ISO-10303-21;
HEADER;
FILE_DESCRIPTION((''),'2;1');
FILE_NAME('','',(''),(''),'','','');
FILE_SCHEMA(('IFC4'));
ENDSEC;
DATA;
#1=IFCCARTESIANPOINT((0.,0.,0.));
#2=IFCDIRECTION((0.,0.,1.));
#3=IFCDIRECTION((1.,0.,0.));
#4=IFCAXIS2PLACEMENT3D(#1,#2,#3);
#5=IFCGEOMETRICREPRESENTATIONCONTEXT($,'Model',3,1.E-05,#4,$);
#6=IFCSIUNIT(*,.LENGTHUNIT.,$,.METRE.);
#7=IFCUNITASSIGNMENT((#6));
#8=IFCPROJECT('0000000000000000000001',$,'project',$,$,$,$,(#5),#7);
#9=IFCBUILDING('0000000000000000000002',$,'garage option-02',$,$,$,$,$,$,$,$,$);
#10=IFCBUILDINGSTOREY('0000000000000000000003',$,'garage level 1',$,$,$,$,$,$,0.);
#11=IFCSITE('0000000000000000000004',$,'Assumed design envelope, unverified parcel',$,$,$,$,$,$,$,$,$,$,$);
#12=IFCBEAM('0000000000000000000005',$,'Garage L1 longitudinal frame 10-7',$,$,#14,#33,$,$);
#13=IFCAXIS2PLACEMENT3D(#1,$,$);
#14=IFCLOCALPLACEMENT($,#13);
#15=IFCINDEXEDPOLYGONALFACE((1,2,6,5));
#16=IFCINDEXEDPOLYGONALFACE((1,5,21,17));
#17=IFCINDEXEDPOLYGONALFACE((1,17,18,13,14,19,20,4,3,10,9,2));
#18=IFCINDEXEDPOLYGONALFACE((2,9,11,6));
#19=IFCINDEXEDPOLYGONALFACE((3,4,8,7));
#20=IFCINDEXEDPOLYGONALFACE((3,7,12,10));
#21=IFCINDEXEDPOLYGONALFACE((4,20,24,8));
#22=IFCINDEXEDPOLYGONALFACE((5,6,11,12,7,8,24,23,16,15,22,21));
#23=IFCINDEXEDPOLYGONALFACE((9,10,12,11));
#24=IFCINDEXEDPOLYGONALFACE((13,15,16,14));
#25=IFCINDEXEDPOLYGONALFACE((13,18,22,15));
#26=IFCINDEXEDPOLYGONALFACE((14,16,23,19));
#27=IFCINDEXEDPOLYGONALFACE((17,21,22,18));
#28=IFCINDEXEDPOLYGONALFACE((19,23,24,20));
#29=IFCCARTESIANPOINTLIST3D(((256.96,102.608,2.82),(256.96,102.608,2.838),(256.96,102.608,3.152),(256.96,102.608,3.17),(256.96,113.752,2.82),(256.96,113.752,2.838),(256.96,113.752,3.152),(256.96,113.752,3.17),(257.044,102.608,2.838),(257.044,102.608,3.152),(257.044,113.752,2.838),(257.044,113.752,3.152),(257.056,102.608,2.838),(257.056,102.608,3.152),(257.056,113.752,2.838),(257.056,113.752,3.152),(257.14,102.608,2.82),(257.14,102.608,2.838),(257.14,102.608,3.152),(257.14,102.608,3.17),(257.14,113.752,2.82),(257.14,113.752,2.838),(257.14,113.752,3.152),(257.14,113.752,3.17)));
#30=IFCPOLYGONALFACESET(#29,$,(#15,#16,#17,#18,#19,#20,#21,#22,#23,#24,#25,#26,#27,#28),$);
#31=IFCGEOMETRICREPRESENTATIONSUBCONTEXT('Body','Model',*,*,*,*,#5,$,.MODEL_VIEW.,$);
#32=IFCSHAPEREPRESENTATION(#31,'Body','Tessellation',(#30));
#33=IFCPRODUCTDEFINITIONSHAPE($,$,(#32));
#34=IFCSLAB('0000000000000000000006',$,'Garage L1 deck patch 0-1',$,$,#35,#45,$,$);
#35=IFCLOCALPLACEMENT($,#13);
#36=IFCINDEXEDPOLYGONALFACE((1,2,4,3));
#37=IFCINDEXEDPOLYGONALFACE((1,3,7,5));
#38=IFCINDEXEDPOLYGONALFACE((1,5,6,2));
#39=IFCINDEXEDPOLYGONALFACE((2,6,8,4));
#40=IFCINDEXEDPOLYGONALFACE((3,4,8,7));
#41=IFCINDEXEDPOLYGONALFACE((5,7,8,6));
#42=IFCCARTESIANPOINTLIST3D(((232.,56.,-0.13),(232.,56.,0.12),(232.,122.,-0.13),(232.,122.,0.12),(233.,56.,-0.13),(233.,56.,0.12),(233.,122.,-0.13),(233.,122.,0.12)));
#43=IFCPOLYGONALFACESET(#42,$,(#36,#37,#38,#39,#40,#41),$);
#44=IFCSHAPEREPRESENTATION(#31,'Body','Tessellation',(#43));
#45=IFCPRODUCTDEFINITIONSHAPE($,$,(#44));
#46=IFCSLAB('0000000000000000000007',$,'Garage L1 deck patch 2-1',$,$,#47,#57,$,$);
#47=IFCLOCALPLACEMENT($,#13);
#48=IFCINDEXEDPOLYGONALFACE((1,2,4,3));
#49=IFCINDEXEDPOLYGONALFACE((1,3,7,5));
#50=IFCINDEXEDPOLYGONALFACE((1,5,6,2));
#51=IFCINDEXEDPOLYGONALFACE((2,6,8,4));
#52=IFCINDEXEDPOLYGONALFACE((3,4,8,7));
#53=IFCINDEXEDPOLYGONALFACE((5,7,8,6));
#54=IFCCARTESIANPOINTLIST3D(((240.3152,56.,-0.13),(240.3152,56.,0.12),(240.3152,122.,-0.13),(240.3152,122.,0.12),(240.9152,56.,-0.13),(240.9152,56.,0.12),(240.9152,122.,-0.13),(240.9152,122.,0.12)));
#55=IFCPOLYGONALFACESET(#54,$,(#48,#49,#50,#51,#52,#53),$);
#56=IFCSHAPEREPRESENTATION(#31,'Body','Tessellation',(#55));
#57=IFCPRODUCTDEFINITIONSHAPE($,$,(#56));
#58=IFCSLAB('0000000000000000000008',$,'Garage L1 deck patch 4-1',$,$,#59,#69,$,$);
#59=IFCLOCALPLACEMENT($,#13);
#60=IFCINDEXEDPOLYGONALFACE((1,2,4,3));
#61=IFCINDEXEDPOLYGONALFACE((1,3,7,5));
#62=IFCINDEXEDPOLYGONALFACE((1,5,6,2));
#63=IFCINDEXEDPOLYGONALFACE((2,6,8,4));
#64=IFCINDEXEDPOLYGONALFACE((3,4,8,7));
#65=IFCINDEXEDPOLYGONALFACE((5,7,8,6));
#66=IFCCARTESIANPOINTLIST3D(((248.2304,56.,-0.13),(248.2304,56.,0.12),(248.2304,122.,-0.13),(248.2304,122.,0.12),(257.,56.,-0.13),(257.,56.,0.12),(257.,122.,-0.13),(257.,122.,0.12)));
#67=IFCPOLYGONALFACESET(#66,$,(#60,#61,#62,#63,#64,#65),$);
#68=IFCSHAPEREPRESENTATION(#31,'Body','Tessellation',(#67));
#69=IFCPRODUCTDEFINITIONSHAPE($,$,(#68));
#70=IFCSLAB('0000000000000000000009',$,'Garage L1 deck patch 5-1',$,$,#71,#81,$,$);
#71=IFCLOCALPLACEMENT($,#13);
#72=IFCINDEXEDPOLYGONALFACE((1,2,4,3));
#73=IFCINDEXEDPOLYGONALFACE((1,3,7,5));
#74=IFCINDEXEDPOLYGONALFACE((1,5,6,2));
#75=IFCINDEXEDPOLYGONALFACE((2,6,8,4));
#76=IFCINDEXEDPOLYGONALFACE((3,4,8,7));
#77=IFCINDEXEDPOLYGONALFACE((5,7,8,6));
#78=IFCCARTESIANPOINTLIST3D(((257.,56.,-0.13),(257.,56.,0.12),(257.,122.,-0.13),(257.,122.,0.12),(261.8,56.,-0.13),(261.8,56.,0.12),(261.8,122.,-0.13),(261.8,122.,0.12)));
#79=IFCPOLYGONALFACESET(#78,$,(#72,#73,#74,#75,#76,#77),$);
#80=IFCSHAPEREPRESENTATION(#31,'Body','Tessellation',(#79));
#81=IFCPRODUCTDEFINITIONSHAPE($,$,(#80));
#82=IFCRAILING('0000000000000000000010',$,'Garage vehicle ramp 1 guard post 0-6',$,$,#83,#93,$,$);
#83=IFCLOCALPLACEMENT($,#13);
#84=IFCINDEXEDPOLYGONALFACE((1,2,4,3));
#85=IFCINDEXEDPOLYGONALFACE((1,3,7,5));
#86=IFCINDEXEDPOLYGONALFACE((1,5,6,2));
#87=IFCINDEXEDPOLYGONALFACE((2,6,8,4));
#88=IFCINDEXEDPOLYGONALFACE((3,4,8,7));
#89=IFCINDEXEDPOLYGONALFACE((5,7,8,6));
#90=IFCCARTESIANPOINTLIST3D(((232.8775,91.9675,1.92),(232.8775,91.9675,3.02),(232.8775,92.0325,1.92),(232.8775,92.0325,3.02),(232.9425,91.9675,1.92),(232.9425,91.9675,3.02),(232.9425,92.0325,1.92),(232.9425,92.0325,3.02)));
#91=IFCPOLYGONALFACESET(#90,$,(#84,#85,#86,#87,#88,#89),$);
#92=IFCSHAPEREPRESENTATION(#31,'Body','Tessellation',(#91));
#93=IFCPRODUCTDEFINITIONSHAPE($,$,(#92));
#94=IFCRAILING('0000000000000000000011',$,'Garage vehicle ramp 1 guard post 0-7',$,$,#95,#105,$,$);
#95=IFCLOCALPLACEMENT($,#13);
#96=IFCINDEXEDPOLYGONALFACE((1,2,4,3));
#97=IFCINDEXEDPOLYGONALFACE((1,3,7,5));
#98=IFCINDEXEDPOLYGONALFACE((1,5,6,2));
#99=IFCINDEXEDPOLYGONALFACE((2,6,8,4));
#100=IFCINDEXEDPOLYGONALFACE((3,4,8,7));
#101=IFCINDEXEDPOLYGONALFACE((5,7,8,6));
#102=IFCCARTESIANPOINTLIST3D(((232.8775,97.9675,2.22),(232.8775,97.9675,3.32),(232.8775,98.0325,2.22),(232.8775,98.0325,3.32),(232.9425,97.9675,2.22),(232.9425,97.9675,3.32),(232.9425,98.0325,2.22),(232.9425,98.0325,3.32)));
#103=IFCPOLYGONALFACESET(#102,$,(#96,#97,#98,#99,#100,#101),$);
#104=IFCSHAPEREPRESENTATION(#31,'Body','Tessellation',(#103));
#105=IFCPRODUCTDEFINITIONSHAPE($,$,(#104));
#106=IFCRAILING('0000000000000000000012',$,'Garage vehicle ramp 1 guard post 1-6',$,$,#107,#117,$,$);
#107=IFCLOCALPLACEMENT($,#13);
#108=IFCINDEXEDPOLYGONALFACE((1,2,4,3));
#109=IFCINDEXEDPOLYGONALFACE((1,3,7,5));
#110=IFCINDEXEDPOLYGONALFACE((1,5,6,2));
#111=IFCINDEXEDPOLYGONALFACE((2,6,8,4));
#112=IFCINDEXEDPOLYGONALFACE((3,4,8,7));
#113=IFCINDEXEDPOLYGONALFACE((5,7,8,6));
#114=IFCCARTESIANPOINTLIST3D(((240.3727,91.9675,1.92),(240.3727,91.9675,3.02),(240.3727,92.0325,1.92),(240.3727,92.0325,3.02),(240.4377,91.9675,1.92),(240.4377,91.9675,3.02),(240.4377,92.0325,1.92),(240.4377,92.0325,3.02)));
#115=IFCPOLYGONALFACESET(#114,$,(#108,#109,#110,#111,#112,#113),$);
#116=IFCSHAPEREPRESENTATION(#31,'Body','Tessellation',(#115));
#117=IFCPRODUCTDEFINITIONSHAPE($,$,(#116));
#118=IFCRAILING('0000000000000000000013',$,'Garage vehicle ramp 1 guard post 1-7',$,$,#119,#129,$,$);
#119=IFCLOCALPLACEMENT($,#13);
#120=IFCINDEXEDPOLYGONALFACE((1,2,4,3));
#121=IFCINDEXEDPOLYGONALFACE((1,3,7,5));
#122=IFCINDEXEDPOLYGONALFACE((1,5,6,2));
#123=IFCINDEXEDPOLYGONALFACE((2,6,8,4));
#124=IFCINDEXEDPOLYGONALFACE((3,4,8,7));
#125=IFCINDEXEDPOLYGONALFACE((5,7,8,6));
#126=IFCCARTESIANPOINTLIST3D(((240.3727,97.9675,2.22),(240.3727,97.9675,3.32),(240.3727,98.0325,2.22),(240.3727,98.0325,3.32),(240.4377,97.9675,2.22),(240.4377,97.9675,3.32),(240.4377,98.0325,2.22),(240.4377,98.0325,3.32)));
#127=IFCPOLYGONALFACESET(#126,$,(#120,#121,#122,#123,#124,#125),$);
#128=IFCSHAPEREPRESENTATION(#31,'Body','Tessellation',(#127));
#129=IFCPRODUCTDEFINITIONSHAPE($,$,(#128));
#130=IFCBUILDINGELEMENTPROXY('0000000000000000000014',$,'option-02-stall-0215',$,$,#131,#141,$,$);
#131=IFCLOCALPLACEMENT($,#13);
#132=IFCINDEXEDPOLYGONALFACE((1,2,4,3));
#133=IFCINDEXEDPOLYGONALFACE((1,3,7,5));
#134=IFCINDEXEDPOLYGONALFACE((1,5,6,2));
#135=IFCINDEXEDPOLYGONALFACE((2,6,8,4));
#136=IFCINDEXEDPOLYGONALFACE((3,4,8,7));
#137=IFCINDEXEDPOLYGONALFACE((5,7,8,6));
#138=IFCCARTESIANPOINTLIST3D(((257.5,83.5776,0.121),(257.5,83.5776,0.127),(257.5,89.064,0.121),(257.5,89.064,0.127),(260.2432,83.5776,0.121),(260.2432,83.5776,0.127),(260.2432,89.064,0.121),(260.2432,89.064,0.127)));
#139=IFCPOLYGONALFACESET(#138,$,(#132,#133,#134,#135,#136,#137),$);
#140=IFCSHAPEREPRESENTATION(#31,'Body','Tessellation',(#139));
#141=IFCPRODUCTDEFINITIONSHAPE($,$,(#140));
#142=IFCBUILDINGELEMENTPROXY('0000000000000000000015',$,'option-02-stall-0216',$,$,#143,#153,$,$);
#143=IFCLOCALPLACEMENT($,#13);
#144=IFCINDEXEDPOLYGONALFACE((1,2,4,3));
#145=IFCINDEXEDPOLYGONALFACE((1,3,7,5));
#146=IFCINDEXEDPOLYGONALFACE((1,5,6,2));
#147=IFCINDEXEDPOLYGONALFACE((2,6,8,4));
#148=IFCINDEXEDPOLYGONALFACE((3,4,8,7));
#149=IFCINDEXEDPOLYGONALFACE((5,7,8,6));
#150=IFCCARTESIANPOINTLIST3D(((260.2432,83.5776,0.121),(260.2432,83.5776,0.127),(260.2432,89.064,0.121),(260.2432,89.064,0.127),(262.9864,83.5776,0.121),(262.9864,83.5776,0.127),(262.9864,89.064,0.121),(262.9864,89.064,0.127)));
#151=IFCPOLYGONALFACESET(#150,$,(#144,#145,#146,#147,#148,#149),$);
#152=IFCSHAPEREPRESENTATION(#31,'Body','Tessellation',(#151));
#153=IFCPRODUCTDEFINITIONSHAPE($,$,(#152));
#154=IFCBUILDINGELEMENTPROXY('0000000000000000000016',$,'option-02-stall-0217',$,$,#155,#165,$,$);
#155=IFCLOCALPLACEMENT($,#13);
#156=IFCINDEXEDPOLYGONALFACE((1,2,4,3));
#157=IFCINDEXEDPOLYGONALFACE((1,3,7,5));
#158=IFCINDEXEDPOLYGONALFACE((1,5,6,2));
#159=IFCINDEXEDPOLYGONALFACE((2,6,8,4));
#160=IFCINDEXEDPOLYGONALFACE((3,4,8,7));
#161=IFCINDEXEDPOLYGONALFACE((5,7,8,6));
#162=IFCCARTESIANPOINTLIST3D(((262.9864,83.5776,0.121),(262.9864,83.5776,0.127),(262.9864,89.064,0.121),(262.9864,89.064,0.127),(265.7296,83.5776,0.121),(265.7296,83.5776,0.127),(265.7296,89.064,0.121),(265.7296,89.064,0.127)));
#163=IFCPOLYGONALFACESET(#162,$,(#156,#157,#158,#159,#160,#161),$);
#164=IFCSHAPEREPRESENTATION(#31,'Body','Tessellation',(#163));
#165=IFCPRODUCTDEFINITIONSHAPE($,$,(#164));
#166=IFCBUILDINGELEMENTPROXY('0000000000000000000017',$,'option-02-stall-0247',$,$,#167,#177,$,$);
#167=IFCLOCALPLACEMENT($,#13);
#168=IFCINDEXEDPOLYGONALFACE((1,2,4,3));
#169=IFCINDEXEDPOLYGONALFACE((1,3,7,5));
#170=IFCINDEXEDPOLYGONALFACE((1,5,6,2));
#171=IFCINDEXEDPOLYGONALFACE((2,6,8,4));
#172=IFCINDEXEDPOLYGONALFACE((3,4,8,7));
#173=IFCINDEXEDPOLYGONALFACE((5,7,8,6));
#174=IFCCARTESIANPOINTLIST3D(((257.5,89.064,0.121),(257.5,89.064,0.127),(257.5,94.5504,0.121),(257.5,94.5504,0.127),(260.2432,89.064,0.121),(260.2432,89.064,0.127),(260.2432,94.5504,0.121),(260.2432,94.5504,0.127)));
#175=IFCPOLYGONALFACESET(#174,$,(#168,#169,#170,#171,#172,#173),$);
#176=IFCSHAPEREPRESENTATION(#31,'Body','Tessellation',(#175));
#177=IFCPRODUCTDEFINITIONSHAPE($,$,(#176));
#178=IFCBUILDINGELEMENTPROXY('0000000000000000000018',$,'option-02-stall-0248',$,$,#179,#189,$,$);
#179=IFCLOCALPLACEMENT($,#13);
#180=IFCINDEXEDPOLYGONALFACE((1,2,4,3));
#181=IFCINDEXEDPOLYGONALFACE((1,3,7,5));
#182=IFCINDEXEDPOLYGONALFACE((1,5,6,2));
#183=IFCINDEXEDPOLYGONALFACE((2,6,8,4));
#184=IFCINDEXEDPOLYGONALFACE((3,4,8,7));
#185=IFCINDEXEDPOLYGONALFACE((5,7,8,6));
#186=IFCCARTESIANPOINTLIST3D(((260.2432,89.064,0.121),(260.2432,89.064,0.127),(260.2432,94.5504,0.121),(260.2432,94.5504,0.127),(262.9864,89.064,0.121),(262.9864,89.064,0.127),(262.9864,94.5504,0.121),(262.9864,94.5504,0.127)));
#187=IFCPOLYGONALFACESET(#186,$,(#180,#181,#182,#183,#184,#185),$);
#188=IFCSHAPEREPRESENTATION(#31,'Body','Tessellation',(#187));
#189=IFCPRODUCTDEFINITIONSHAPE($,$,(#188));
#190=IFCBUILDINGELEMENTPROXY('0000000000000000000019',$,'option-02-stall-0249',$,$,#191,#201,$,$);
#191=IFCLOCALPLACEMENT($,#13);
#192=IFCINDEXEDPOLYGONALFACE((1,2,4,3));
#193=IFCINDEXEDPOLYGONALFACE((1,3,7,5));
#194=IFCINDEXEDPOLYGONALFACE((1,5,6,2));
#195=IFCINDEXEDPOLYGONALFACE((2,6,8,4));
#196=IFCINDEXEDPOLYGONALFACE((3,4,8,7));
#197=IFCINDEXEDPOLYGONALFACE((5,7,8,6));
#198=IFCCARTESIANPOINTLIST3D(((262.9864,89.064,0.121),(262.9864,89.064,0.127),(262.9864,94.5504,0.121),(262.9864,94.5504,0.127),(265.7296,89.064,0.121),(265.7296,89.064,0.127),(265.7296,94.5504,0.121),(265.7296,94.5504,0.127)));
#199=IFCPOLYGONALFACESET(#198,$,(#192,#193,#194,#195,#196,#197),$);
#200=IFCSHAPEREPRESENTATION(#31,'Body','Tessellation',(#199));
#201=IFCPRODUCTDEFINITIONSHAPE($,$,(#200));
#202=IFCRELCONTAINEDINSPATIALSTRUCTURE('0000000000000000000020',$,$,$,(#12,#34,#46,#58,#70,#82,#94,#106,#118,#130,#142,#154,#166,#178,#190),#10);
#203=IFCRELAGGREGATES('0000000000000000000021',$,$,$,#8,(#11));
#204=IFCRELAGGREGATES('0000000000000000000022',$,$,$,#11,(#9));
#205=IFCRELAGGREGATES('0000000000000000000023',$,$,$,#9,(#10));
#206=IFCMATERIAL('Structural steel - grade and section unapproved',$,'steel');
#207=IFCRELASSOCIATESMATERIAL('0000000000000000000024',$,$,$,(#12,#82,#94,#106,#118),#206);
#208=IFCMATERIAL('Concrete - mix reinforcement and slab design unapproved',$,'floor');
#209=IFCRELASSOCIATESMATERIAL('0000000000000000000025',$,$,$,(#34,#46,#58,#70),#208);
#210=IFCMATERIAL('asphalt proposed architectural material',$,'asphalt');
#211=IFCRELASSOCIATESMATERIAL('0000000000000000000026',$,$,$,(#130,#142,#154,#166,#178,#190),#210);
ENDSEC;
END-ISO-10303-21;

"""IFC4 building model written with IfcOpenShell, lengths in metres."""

from ifc_helpers import new_model, si_unit, frame, origin_with_axes, place, context, subcontext, project, spatial, rectangle, i_section, extrude, material, element, save


model = new_model("IFC4")

# Units and contexts
model_context = context("Model", 3, precision=1e-05, world=origin_with_axes())
body_context = subcontext(model_context, "Body", "Model", "MODEL_VIEW")
ifc_project = project(units=[si_unit("LENGTHUNIT", "METRE")], contexts=[model_context])

# Site, building, storey
site = spatial("IfcSite", under=ifc_project, Name="Assumed design envelope, unverified parcel")
building = spatial("IfcBuilding", under=site, Name="garage option-02")
storey = spatial("IfcBuildingStorey", under=building, Name="garage level 1", Elevation=0.0)

# Shared definitions
ifc_material_1 = material(Name="Concrete - mix reinforcement and slab design unapproved", Category="floor")

# Beam
ifc_material_2 = material(Name="Structural steel - grade and section unapproved", Category="steel")
beam_1_placement = place(None, frame((257.05, 102.608, 2.995), z_axis=(0.0, 1.0, 0.0), x_axis=(-1.0, 0.0, 0.0)))
element("IfcBeam", 1, at=beam_1_placement, inside=storey, material=ifc_material_2, Name="Garage L1 longitudinal frame 10-7", context=body_context, shape_type="SweptSolid", body=[
    extrude(i_section(OverallWidth=0.18, OverallDepth=0.35, WebThickness=0.012, FlangeThickness=0.018, FilletRadius=0.0), origin_with_axes(), (0.0, 0.0, 1.0), 11.144),
])

# Slabs
slab_1_placement = place(None, frame((232.5, 89.0, -0.13), z_axis=(0.0, 0.0, 1.0), x_axis=(1.0, 0.0, 0.0)))
element("IfcSlab", 2, at=slab_1_placement, inside=storey, material=ifc_material_1, Name="Garage L1 deck patch 0-1", context=body_context, shape_type="SweptSolid", body=[
    extrude(rectangle(XDim=1.0, YDim=66.0), origin_with_axes(), (0.0, 0.0, 1.0), 0.25),
])
slab_2_placement = place(None, frame((240.6152, 89.0, -0.13), z_axis=(0.0, 0.0, 1.0), x_axis=(1.0, 0.0, 0.0)))
element("IfcSlab", 3, at=slab_2_placement, inside=storey, material=ifc_material_1, Name="Garage L1 deck patch 2-1", context=body_context, shape_type="SweptSolid", body=[
    extrude(rectangle(XDim=0.6, YDim=66.0), origin_with_axes(), (0.0, 0.0, 1.0), 0.25),
])
slab_3_placement = place(None, frame((252.6152, 89.0, -0.13), z_axis=(0.0, 0.0, 1.0), x_axis=(1.0, 0.0, 0.0)))
element("IfcSlab", 4, at=slab_3_placement, inside=storey, material=ifc_material_1, Name="Garage L1 deck patch 4-1", context=body_context, shape_type="SweptSolid", body=[
    extrude(rectangle(XDim=8.7696, YDim=66.0), origin_with_axes(), (0.0, 0.0, 1.0), 0.25),
])
slab_4_placement = place(None, frame((259.4, 89.0, -0.13), z_axis=(0.0, 0.0, 1.0), x_axis=(1.0, 0.0, 0.0)))
element("IfcSlab", 5, at=slab_4_placement, inside=storey, material=ifc_material_1, Name="Garage L1 deck patch 5-1", context=body_context, shape_type="SweptSolid", body=[
    extrude(rectangle(XDim=4.8, YDim=66.0), origin_with_axes(), (0.0, 0.0, 1.0), 0.25),
])

# Railings
railing_1_placement = place(None, frame((232.91, 92.0, 1.92), z_axis=(0.0, 0.0, 1.0), x_axis=(-1.0, 0.0, 0.0)))
element("IfcRailing", 6, at=railing_1_placement, inside=storey, material=ifc_material_2, Name="Garage vehicle ramp 1 guard post 0-6", context=body_context, shape_type="SweptSolid", body=[
    extrude(rectangle(XDim=0.065, YDim=0.065), origin_with_axes(), (0.0, 0.0, 1.0), 1.1),
])
railing_2_placement = place(None, frame((232.91, 98.0, 2.22), z_axis=(0.0, 0.0, 1.0), x_axis=(-1.0, 0.0, 0.0)))
element("IfcRailing", 7, at=railing_2_placement, inside=storey, material=ifc_material_2, Name="Garage vehicle ramp 1 guard post 0-7", context=body_context, shape_type="SweptSolid", body=[
    extrude(rectangle(XDim=0.065, YDim=0.065), origin_with_axes(), (0.0, 0.0, 1.0), 1.1),
])
railing_3_placement = place(None, frame((240.4052, 92.0, 1.92), z_axis=(0.0, 0.0, 1.0), x_axis=(-1.0, 0.0, 0.0)))
element("IfcRailing", 8, at=railing_3_placement, inside=storey, material=ifc_material_2, Name="Garage vehicle ramp 1 guard post 1-6", context=body_context, shape_type="SweptSolid", body=[
    extrude(rectangle(XDim=0.065, YDim=0.065), origin_with_axes(), (0.0, 0.0, 1.0), 1.1),
])
railing_4_placement = place(None, frame((240.4052, 98.0, 2.22), z_axis=(0.0, 0.0, 1.0), x_axis=(-1.0, 0.0, 0.0)))
element("IfcRailing", 9, at=railing_4_placement, inside=storey, material=ifc_material_2, Name="Garage vehicle ramp 1 guard post 1-7", context=body_context, shape_type="SweptSolid", body=[
    extrude(rectangle(XDim=0.065, YDim=0.065), origin_with_axes(), (0.0, 0.0, 1.0), 1.1),
])

# Building element proxies
ifc_material_3 = material(Name="asphalt proposed architectural material", Category="asphalt")
for number, where, z_axis, x_axis, name in (
    (10, (258.8716, 86.3208, 0.121), (0.0, 0.0, 1.0), (1.0, 0.0, 0.0), "option-02-stall-0215"),
    (11, (261.6148, 86.3208, 0.121), (0.0, 0.0, 1.0), (1.0, 0.0, 0.0), "option-02-stall-0216"),
    (12, (264.358, 86.3208, 0.121), (0.0, 0.0, 1.0), (1.0, 0.0, 0.0), "option-02-stall-0217"),
    (13, (258.8716, 91.8072, 0.121), (0.0, 0.0, 1.0), (1.0, 0.0, 0.0), "option-02-stall-0247"),
    (14, (261.6148, 91.8072, 0.121), (0.0, 0.0, 1.0), (1.0, 0.0, 0.0), "option-02-stall-0248"),
    (15, (264.358, 91.8072, 0.121), (0.0, 0.0, 1.0), (1.0, 0.0, 0.0), "option-02-stall-0249"),
):
    element("IfcBuildingElementProxy", number, at=place(None, frame(where, z_axis=z_axis, x_axis=x_axis)), inside=storey, material=ifc_material_3, Name=name, context=body_context, shape_type="SweptSolid", body=[
        extrude(rectangle(XDim=2.7432, YDim=5.4864), origin_with_axes(), (0.0, 0.0, 1.0), 0.006),
    ])

save(model, "model.ifc")
